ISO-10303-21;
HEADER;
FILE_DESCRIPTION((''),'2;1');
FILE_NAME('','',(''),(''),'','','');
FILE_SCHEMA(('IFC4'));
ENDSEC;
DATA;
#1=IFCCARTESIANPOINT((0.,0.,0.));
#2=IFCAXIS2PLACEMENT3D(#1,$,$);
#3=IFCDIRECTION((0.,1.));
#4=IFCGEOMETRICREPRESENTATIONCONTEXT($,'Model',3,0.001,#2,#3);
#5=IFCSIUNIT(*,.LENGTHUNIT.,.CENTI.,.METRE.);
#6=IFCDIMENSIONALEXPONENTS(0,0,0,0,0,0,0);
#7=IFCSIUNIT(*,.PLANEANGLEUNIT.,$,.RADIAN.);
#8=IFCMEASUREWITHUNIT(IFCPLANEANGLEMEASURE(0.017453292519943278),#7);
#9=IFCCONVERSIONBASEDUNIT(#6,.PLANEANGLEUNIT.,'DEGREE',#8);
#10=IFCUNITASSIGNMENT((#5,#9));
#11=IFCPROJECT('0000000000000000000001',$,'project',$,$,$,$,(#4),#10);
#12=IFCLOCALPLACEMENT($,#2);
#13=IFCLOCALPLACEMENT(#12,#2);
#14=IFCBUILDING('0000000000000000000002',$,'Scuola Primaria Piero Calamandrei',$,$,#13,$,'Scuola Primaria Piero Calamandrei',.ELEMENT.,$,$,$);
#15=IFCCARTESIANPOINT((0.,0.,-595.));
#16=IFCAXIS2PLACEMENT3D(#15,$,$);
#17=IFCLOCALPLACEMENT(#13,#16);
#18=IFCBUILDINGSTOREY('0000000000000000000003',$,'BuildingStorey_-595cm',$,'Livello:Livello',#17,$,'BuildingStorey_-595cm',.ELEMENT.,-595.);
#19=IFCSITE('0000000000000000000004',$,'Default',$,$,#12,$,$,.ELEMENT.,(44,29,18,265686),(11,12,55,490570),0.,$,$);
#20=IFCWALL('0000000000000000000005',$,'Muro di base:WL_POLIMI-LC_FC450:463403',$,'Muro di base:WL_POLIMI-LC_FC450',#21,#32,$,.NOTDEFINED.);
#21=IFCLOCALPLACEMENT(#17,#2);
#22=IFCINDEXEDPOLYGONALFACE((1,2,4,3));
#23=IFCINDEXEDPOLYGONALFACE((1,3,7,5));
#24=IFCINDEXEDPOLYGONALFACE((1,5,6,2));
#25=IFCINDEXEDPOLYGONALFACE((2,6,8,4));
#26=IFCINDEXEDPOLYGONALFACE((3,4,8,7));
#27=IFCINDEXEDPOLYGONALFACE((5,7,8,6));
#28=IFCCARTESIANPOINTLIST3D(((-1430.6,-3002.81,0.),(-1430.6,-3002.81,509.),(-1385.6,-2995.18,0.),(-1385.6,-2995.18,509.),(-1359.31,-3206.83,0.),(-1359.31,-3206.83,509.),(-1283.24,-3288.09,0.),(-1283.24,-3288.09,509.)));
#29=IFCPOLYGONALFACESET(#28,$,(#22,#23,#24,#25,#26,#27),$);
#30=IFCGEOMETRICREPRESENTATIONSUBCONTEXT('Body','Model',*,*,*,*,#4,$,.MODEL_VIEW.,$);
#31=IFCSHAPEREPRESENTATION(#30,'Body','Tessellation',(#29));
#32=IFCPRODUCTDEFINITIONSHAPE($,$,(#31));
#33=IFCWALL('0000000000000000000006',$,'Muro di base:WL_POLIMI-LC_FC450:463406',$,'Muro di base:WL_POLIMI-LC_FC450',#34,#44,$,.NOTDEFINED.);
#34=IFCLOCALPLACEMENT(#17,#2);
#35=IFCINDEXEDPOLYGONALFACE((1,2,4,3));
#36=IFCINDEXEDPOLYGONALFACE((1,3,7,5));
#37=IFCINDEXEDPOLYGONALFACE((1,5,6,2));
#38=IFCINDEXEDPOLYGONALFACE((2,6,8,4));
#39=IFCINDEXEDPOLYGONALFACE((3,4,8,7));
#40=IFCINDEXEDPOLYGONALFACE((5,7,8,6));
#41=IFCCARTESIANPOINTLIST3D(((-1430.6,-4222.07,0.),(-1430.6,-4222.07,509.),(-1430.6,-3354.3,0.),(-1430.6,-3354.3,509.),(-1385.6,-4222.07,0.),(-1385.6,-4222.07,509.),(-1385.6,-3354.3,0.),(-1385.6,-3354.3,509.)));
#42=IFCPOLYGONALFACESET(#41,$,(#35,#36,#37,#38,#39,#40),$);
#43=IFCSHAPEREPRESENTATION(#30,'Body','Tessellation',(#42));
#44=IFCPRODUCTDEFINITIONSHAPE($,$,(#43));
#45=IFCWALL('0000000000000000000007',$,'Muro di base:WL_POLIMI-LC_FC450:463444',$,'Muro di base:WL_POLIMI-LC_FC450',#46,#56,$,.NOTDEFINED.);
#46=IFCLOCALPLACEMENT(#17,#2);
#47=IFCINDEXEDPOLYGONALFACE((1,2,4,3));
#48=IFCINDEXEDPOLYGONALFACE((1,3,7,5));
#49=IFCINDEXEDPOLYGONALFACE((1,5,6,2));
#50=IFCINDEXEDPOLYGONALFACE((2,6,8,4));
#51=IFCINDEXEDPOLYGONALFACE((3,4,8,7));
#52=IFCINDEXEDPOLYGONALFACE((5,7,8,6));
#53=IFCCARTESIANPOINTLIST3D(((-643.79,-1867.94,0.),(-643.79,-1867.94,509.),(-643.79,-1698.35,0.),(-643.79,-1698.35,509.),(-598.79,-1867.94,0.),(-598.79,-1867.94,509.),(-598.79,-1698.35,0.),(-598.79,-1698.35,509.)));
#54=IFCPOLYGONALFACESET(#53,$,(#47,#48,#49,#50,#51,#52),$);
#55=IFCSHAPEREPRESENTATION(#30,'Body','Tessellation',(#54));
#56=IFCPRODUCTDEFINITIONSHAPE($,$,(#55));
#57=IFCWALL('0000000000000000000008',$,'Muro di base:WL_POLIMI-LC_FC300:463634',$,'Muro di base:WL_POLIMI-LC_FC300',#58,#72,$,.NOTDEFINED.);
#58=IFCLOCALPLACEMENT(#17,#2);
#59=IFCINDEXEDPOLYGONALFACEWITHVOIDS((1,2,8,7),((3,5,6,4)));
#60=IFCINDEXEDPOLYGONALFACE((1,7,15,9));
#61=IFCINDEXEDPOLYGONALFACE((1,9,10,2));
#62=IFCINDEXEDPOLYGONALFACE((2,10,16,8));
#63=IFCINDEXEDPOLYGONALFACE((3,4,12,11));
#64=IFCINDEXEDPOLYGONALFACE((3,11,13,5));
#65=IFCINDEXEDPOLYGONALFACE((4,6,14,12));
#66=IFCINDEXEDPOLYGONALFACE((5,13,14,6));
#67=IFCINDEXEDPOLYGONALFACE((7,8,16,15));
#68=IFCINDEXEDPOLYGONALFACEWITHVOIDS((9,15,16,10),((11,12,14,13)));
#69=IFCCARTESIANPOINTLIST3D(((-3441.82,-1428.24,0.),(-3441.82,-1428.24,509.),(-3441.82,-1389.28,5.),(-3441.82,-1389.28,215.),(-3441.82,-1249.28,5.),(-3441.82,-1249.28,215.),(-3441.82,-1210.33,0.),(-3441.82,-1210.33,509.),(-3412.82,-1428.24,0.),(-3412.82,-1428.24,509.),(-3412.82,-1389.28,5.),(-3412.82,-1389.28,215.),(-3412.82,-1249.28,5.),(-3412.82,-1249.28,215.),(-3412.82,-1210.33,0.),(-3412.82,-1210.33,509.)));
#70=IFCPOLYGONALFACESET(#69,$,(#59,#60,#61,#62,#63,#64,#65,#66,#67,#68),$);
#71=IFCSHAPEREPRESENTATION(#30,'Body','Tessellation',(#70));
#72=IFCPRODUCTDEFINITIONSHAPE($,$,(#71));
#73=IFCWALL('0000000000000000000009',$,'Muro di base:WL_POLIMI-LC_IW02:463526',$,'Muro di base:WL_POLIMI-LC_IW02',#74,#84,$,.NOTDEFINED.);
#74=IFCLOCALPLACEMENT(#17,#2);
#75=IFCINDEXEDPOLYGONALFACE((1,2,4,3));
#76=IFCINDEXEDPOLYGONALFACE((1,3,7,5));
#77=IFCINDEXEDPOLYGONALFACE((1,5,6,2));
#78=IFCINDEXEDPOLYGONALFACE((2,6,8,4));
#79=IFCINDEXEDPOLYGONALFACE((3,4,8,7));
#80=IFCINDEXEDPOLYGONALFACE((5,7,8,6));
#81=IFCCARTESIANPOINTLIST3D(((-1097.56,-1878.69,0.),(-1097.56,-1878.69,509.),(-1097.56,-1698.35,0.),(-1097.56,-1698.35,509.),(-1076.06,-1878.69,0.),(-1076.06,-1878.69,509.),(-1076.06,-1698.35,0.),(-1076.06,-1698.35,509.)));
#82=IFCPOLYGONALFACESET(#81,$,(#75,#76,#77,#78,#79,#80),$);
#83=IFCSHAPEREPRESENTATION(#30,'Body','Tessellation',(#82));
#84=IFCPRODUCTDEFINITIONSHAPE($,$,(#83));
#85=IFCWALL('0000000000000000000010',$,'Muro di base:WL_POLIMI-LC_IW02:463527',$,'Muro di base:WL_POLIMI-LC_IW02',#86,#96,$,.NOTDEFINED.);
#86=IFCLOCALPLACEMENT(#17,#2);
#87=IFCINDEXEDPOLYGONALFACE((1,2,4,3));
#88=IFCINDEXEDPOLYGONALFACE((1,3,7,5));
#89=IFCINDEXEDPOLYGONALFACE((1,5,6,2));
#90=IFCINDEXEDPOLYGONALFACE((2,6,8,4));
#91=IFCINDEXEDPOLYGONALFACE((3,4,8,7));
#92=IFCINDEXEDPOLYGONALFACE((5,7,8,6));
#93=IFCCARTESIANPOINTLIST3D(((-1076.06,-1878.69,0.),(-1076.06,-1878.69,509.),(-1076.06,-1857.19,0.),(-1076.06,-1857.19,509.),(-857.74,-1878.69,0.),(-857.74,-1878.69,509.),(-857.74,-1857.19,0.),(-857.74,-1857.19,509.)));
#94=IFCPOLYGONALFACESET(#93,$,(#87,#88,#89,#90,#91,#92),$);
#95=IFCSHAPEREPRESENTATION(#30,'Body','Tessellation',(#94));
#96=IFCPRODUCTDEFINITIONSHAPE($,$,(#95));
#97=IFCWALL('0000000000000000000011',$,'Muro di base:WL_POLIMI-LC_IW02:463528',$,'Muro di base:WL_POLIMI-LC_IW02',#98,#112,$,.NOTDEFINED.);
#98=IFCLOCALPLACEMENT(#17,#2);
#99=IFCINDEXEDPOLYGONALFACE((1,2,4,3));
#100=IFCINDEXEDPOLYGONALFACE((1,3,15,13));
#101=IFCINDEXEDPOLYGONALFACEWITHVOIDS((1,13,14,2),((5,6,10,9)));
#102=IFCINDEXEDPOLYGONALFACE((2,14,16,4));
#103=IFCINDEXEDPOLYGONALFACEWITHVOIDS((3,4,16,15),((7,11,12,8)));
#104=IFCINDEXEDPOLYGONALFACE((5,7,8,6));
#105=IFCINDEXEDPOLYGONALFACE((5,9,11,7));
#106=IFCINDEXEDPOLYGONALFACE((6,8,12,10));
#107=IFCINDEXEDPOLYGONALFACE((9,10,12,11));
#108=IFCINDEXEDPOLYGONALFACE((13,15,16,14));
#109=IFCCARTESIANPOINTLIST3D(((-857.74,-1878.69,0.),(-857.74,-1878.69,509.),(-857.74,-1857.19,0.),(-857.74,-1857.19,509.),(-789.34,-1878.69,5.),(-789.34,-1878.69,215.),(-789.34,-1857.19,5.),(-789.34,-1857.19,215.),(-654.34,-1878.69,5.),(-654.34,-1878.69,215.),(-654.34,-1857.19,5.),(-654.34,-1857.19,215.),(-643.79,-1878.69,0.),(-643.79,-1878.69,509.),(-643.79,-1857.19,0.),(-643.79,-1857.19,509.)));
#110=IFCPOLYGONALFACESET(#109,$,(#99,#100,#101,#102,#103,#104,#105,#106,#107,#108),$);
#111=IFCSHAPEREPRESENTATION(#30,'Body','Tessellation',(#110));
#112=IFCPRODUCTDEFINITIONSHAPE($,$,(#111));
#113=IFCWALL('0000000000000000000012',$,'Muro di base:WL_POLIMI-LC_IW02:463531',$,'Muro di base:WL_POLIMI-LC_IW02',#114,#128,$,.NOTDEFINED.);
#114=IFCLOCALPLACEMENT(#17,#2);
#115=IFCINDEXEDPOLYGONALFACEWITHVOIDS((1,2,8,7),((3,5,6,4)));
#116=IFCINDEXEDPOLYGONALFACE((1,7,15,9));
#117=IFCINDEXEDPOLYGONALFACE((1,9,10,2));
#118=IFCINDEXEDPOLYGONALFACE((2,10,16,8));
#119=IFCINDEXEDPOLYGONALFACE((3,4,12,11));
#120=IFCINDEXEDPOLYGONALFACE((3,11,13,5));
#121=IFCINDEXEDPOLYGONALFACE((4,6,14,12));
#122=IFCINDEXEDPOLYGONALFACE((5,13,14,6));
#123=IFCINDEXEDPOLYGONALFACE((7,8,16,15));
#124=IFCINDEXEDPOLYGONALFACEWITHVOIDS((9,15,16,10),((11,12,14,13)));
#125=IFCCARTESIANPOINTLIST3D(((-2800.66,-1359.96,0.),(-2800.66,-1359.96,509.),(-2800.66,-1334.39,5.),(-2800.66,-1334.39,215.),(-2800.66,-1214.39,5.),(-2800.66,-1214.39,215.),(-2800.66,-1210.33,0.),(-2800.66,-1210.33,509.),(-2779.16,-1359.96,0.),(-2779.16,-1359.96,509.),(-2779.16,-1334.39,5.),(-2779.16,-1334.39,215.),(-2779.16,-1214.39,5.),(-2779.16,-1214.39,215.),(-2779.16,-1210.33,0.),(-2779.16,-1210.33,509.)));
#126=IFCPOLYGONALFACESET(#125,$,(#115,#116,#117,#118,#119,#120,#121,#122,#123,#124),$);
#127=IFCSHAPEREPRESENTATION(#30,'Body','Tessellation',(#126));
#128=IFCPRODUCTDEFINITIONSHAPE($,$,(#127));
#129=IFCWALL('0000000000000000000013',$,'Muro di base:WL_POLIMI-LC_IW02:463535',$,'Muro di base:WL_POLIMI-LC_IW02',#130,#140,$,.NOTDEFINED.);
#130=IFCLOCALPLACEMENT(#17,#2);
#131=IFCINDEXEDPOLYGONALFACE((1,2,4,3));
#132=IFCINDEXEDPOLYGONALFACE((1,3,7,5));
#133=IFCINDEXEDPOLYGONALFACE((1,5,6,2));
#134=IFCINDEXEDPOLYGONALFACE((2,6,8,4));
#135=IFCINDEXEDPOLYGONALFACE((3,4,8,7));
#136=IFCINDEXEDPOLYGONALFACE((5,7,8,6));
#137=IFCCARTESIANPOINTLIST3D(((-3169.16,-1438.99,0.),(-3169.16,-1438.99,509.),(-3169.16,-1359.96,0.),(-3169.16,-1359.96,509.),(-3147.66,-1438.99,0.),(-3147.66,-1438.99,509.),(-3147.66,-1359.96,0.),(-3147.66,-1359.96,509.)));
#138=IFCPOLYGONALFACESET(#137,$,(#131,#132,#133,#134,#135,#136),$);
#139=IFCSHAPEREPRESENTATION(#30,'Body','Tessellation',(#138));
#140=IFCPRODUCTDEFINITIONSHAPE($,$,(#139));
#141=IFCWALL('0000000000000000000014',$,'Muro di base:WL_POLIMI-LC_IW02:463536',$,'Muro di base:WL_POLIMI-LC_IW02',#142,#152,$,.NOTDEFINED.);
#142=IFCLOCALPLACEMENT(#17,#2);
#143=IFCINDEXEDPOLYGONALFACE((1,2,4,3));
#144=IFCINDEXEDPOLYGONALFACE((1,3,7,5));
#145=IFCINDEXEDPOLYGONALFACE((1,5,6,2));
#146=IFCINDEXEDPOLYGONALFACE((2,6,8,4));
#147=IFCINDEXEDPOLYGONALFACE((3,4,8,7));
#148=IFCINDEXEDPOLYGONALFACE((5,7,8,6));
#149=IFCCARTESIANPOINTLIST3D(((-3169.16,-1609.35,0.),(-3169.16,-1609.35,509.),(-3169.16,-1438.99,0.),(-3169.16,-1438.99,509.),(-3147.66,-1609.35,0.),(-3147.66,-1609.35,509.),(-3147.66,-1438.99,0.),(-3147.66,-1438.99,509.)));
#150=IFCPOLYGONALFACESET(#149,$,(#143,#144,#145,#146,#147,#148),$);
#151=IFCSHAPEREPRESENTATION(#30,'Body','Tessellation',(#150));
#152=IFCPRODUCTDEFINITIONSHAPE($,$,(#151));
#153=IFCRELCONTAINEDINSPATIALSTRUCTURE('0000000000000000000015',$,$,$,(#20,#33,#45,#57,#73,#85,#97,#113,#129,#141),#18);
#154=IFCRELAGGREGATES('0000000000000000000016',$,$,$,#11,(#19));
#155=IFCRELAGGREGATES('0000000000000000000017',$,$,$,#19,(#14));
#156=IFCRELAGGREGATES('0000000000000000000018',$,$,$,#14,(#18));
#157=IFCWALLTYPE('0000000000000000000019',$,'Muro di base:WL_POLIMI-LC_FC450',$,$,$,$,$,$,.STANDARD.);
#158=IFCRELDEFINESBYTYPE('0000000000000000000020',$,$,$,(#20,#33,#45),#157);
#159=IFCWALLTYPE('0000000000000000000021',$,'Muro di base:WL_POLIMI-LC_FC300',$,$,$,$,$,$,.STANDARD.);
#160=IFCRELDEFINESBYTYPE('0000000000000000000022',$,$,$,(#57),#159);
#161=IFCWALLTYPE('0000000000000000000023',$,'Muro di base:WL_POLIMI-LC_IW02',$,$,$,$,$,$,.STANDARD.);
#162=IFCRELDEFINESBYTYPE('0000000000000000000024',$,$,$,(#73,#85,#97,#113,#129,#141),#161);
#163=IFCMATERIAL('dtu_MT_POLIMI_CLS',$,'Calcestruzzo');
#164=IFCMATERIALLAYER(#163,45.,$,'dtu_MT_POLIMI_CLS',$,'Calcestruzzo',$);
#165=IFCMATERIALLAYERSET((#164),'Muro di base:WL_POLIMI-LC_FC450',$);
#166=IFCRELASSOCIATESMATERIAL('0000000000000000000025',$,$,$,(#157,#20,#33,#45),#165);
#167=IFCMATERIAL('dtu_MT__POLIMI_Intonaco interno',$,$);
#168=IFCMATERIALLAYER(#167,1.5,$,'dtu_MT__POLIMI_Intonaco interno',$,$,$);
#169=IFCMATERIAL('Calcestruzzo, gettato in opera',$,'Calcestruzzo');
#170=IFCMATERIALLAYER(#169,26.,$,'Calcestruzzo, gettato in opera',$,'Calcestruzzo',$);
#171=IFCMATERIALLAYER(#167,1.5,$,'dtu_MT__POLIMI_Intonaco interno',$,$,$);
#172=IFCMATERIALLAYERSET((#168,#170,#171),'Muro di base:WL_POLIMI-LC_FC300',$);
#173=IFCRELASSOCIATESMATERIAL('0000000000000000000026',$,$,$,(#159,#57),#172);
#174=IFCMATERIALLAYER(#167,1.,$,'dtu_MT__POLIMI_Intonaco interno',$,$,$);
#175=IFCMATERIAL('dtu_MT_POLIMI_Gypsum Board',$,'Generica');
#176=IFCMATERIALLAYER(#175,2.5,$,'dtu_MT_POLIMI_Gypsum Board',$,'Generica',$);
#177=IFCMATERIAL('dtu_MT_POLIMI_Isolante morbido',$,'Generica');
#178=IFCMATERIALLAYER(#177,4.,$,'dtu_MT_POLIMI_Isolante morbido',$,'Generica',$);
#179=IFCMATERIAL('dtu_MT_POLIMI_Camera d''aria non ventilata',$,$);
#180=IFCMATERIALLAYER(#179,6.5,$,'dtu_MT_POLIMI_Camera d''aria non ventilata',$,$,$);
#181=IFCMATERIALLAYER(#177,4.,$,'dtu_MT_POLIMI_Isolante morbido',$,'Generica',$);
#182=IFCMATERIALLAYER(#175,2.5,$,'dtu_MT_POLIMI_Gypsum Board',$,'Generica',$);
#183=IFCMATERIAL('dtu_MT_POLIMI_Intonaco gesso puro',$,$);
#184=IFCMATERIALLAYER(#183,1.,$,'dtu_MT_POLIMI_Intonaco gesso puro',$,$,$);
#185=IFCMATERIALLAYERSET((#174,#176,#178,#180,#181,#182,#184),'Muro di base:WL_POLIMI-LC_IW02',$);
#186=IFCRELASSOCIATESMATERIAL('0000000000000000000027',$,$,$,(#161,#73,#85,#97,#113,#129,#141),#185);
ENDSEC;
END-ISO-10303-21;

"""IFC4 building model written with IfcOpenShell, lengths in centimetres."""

from ifc_helpers import new_model, entity, si_unit, converted_unit, direction, frame, frame_2d, origin, place, context, subcontext, project, spatial, polyline, rectangle, outline, extrude, clip, bounded_halfspace, material, layer, layer_set, layer_usage, type_object, element, save


model = new_model("IFC4")

# Units and contexts
model_context = context("Model", 3, precision=0.001, world=origin(), true_north=direction((0.0, 1.0)))
body_context = subcontext(model_context, "Body", "Model", "MODEL_VIEW")
ifc_project = project(units=[si_unit("LENGTHUNIT", "METRE", prefix="CENTI"), converted_unit("PLANEANGLEUNIT", "DEGREE", entity("IfcPlaneAngleMeasure", 0.017453292519943278), si_unit("PLANEANGLEUNIT", "RADIAN"), dimensions=[0, 0, 0, 0, 0, 0, 0])], contexts=[model_context])

# Site, building, storey
site_placement = place(None, origin())
site = spatial("IfcSite", under=ifc_project, at=site_placement, Name="Default", CompositionType="ELEMENT", RefLatitude=(44, 29, 18, 265686), RefLongitude=(11, 12, 55, 490570), RefElevation=0.0)
building_placement = place(site_placement, origin())
building = spatial("IfcBuilding", under=site, at=building_placement, Name="Scuola Primaria Piero Calamandrei", LongName="Scuola Primaria Piero Calamandrei", CompositionType="ELEMENT")
storey_placement = place(building_placement, frame((0.0, 0.0, -595.0)))
storey = spatial("IfcBuildingStorey", under=building, at=storey_placement, Name="BuildingStorey_-595cm", ObjectType="Livello:Livello", LongName="BuildingStorey_-595cm", CompositionType="ELEMENT", Elevation=-595.0)

# Walls
ifc_material_1 = material(Name="dtu_MT_POLIMI_CLS", Category="Calcestruzzo")
ifc_layer_1 = layer(ifc_material_1, 45.0, Name="dtu_MT_POLIMI_CLS", Category="Calcestruzzo")
ifc_layer_set_1 = layer_set([ifc_layer_1], Name="Muro di base:WL_POLIMI-LC_FC450")
wall_type_1 = type_object("IfcWallType", Name="Muro di base:WL_POLIMI-LC_FC450", PredefinedType="STANDARD", material=ifc_layer_set_1)
ifc_layer_usage_1 = layer_usage(ifc_layer_set_1, "AXIS2", "NEGATIVE", 22.5)
wall_1_placement = place(storey_placement, frame((-1409.36, -2995.39, 0.0), z_axis=(0.0, 0.0, 1.0), x_axis=(0.32988, -0.944023, 0.0)))
element("IfcWall", 1, at=wall_1_placement, inside=storey, type_object=wall_type_1, material=ifc_layer_usage_1, Name="Muro di base:WL_POLIMI-LC_FC450:463403", ObjectType="Muro di base:WL_POLIMI-LC_FC450", PredefinedType="NOTDEFINED", context=body_context, shape_type="Clipping", body=[
    clip(extrude(outline(polyline([(216.11, -22.5), (317.92, 22.5), (218.98, 22.5), (7.64, 22.5), (0.0, -22.5), (216.11, -22.5)])), origin(), (0.0, 0.0, 1.0), 509.0), bounded_halfspace(frame((0.0, -22.5, 509.0), z_axis=(0.0, 0.0, 1.0), x_axis=(0.32988, 0.944023, 0.0)), False, frame((0.0, -22.5, 509.0)), polyline([(0.0, 0.0), (216.11, 0.0), (317.92, 45.0), (218.98, 45.0), (7.64, 45.0), (0.0, 0.0)]))),
])
ifc_layer_usage_2 = layer_usage(ifc_layer_set_1, "AXIS2", "NEGATIVE", 22.5)
wall_2_placement = place(storey_placement, frame((-1408.1, -3354.3, 0.0), z_axis=(0.0, 0.0, 1.0), x_axis=(0.0, -1.0, 0.0)))
element("IfcWall", 2, at=wall_2_placement, inside=storey, type_object=wall_type_1, material=ifc_layer_usage_2, Name="Muro di base:WL_POLIMI-LC_FC450:463406", ObjectType="Muro di base:WL_POLIMI-LC_FC450", PredefinedType="NOTDEFINED", context=body_context, shape_type="Clipping", body=[
    clip(extrude(rectangle(XDim=867.78, YDim=45.0, at=frame_2d((433.89, 0.0), x_axis=(-1.0, 0.0))), origin(), (0.0, 0.0, 1.0), 509.0), bounded_halfspace(frame((0.0, -22.5, 509.0), z_axis=(0.0, 0.0, 1.0), x_axis=(0.0, 1.0, 0.0)), False, frame((0.0, -22.5, 509.0)), polyline([(0.0, 0.0), (867.78, 0.0), (867.78, 45.0), (0.0, 45.0), (0.0, 0.0)]))),
])
ifc_layer_usage_3 = layer_usage(ifc_layer_set_1, "AXIS2", "NEGATIVE", 22.5)
wall_3_placement = place(storey_placement, frame((-621.29, -1698.35, 0.0), z_axis=(0.0, 0.0, 1.0), x_axis=(0.0, -1.0, 0.0)))
element("IfcWall", 3, at=wall_3_placement, inside=storey, type_object=wall_type_1, material=ifc_layer_usage_3, Name="Muro di base:WL_POLIMI-LC_FC450:463444", ObjectType="Muro di base:WL_POLIMI-LC_FC450", PredefinedType="NOTDEFINED", context=body_context, shape_type="Clipping", body=[
    clip(extrude(rectangle(XDim=169.58, YDim=45.0, at=frame_2d((84.79, 0.0), x_axis=(-1.0, 0.0))), origin(), (0.0, 0.0, 1.0), 509.0), bounded_halfspace(frame((0.0, -22.5, 509.0), z_axis=(0.0, 0.0, 1.0), x_axis=(0.0, 1.0, 0.0)), False, frame((0.0, -22.5, 509.0)), polyline([(0.0, 0.0), (10.75, 0.0), (158.83, 0.0), (169.58, 0.0), (169.58, 45.0), (0.0, 45.0), (0.0, 0.0)]))),
])

# Wall, opening
ifc_material_2 = material(Name="dtu_MT__POLIMI_Intonaco interno")
ifc_layer_2 = layer(ifc_material_2, 1.5, Name="dtu_MT__POLIMI_Intonaco interno")
ifc_material_3 = material(Name="Calcestruzzo, gettato in opera", Category="Calcestruzzo")
ifc_layer_3 = layer(ifc_material_3, 26.0, Name="Calcestruzzo, gettato in opera", Category="Calcestruzzo")
ifc_layer_4 = layer(ifc_material_2, 1.5, Name="dtu_MT__POLIMI_Intonaco interno")
ifc_layer_set_2 = layer_set([ifc_layer_2, ifc_layer_3, ifc_layer_4], Name="Muro di base:WL_POLIMI-LC_FC300")
ifc_layer_usage_4 = layer_usage(ifc_layer_set_2, "AXIS2", "NEGATIVE", 14.5)
wall_type_2 = type_object("IfcWallType", Name="Muro di base:WL_POLIMI-LC_FC300", PredefinedType="STANDARD", material=ifc_layer_set_2)
wall_4_placement = place(storey_placement, frame((-3427.32, -1428.24, 0.0), z_axis=(0.0, 0.0, 1.0), x_axis=(0.0, 1.0, 0.0)))
wall_4 = element("IfcWall", 4, at=wall_4_placement, inside=storey, type_object=wall_type_2, material=ifc_layer_usage_4, Name="Muro di base:WL_POLIMI-LC_FC300:463634", ObjectType="Muro di base:WL_POLIMI-LC_FC300", PredefinedType="NOTDEFINED", context=body_context, shape_type="SweptSolid", body=[
    extrude(rectangle(XDim=217.91, YDim=29.0, at=frame_2d((108.96, 0.0), x_axis=(-1.0, 0.0))), origin(), (0.0, 0.0, 1.0), 509.0),
])
opening_1_placement = place(wall_4_placement, frame((38.96, -14.5, 5.0)))
element("IfcOpeningElement", 5, at=opening_1_placement, cuts=wall_4, PredefinedType="OPENING", context=body_context, shape_type="SweptSolid", body=[
    extrude(rectangle(XDim=210.0, YDim=140.0, at=frame_2d((105.0, 70.0), x_axis=(1.0, 0.0))), frame((0.0, 0.0, 0.0), z_axis=(0.0, 1.0, 0.0), x_axis=(0.0, 0.0, 1.0)), (0.0, 0.0, 1.0), 29.0),
])

# Walls
ifc_layer_5 = layer(ifc_material_2, 1.0, Name="dtu_MT__POLIMI_Intonaco interno")
ifc_material_4 = material(Name="dtu_MT_POLIMI_Gypsum Board", Category="Generica")
ifc_layer_6 = layer(ifc_material_4, 2.5, Name="dtu_MT_POLIMI_Gypsum Board", Category="Generica")
ifc_material_5 = material(Name="dtu_MT_POLIMI_Isolante morbido", Category="Generica")
ifc_layer_7 = layer(ifc_material_5, 4.0, Name="dtu_MT_POLIMI_Isolante morbido", Category="Generica")
ifc_material_6 = material(Name="dtu_MT_POLIMI_Camera d'aria non ventilata")
ifc_layer_8 = layer(ifc_material_6, 6.5, Name="dtu_MT_POLIMI_Camera d'aria non ventilata")
ifc_layer_9 = layer(ifc_material_5, 4.0, Name="dtu_MT_POLIMI_Isolante morbido", Category="Generica")
ifc_layer_10 = layer(ifc_material_4, 2.5, Name="dtu_MT_POLIMI_Gypsum Board", Category="Generica")
ifc_material_7 = material(Name="dtu_MT_POLIMI_Intonaco gesso puro")
ifc_layer_11 = layer(ifc_material_7, 1.0, Name="dtu_MT_POLIMI_Intonaco gesso puro")
ifc_layer_set_3 = layer_set([ifc_layer_5, ifc_layer_6, ifc_layer_7, ifc_layer_8, ifc_layer_9, ifc_layer_10, ifc_layer_11], Name="Muro di base:WL_POLIMI-LC_IW02")
ifc_layer_usage_5 = layer_usage(ifc_layer_set_3, "AXIS2", "NEGATIVE", 10.75)
wall_type_3 = type_object("IfcWallType", Name="Muro di base:WL_POLIMI-LC_IW02", PredefinedType="STANDARD", material=ifc_layer_set_3)
wall_5_placement = place(storey_placement, frame((-1086.81, -1698.35, 0.0), z_axis=(0.0, 0.0, 1.0), x_axis=(0.0, -1.0, 0.0)))
element("IfcWall", 6, at=wall_5_placement, inside=storey, type_object=wall_type_3, material=ifc_layer_usage_5, Name="Muro di base:WL_POLIMI-LC_IW02:463526", ObjectType="Muro di base:WL_POLIMI-LC_IW02", PredefinedType="NOTDEFINED", context=body_context, shape_type="SweptSolid", body=[
    extrude(rectangle(XDim=180.33, YDim=21.5, at=frame_2d((90.17, 0.0), x_axis=(-1.0, 0.0))), origin(), (0.0, 0.0, 1.0), 509.0),
])
ifc_layer_usage_6 = layer_usage(ifc_layer_set_3, "AXIS2", "NEGATIVE", 10.75)
wall_6_placement = place(storey_placement, frame((-1076.06, -1867.94, 0.0)))
element("IfcWall", 7, at=wall_6_placement, inside=storey, type_object=wall_type_3, material=ifc_layer_usage_6, Name="Muro di base:WL_POLIMI-LC_IW02:463527", ObjectType="Muro di base:WL_POLIMI-LC_IW02", PredefinedType="NOTDEFINED", context=body_context, shape_type="SweptSolid", body=[
    extrude(rectangle(XDim=218.32, YDim=21.5, at=frame_2d((109.16, 0.0), x_axis=(-1.0, 0.0))), origin(), (0.0, 0.0, 1.0), 509.0),
])

# Walls, openings
ifc_layer_usage_7 = layer_usage(ifc_layer_set_3, "AXIS2", "NEGATIVE", 10.75)
wall_7_placement = place(storey_placement, frame((-857.74, -1867.94, 0.0)))
wall_7 = element("IfcWall", 8, at=wall_7_placement, inside=storey, type_object=wall_type_3, material=ifc_layer_usage_7, Name="Muro di base:WL_POLIMI-LC_IW02:463528", ObjectType="Muro di base:WL_POLIMI-LC_IW02", PredefinedType="NOTDEFINED", context=body_context, shape_type="SweptSolid", body=[
    extrude(rectangle(XDim=213.95, YDim=21.5, at=frame_2d((106.98, 0.0), x_axis=(-1.0, 0.0))), origin(), (0.0, 0.0, 1.0), 509.0),
])
opening_2_placement = place(wall_7_placement, frame((203.4, 10.75, 5.0)))
element("IfcOpeningElement", 9, at=opening_2_placement, cuts=wall_7, PredefinedType="OPENING", context=body_context, shape_type="SweptSolid", body=[
    extrude(rectangle(XDim=210.0, YDim=135.0, at=frame_2d((105.0, 67.5), x_axis=(-1.0, 0.0))), frame((0.0, 0.0, 0.0), z_axis=(0.0, -1.0, 0.0), x_axis=(0.0, 0.0, 1.0)), (0.0, 0.0, 1.0), 21.5),
])
ifc_layer_usage_8 = layer_usage(ifc_layer_set_3, "AXIS2", "NEGATIVE", 10.75)
wall_8_placement = place(storey_placement, frame((-2789.91, -1359.96, 0.0), z_axis=(0.0, 0.0, 1.0), x_axis=(0.0, 1.0, 0.0)))
wall_8 = element("IfcWall", 10, at=wall_8_placement, inside=storey, type_object=wall_type_3, material=ifc_layer_usage_8, Name="Muro di base:WL_POLIMI-LC_IW02:463531", ObjectType="Muro di base:WL_POLIMI-LC_IW02", PredefinedType="NOTDEFINED", context=body_context, shape_type="SweptSolid", body=[
    extrude(rectangle(XDim=149.63, YDim=21.5, at=frame_2d((74.82, 0.0), x_axis=(-1.0, 0.0))), origin(), (0.0, 0.0, 1.0), 509.0),
])
opening_3_placement = place(wall_8_placement, frame((25.57, -10.75, 5.0)))
element("IfcOpeningElement", 11, at=opening_3_placement, cuts=wall_8, PredefinedType="OPENING", context=body_context, shape_type="SweptSolid", body=[
    extrude(rectangle(XDim=210.0, YDim=120.0, at=frame_2d((105.0, 60.0), x_axis=(1.0, 0.0))), frame((0.0, 0.0, 0.0), z_axis=(0.0, 1.0, 0.0), x_axis=(0.0, 0.0, 1.0)), (0.0, 0.0, 1.0), 21.5),
])

# Walls
ifc_layer_usage_9 = layer_usage(ifc_layer_set_3, "AXIS2", "NEGATIVE", 10.75)
wall_9_placement = place(storey_placement, frame((-3158.41, -1438.99, 0.0), z_axis=(0.0, 0.0, 1.0), x_axis=(0.0, 1.0, 0.0)))
element("IfcWall", 12, at=wall_9_placement, inside=storey, type_object=wall_type_3, material=ifc_layer_usage_9, Name="Muro di base:WL_POLIMI-LC_IW02:463535", ObjectType="Muro di base:WL_POLIMI-LC_IW02", PredefinedType="NOTDEFINED", context=body_context, shape_type="SweptSolid", body=[
    extrude(rectangle(XDim=79.03, YDim=21.5, at=frame_2d((39.52, 0.0), x_axis=(-1.0, 0.0))), origin(), (0.0, 0.0, 1.0), 509.0),
])
ifc_layer_usage_10 = layer_usage(ifc_layer_set_3, "AXIS2", "NEGATIVE", 10.75)
wall_10_placement = place(storey_placement, frame((-3158.41, -1609.35, 0.0), z_axis=(0.0, 0.0, 1.0), x_axis=(0.0, 1.0, 0.0)))
element("IfcWall", 13, at=wall_10_placement, inside=storey, type_object=wall_type_3, material=ifc_layer_usage_10, Name="Muro di base:WL_POLIMI-LC_IW02:463536", ObjectType="Muro di base:WL_POLIMI-LC_IW02", PredefinedType="NOTDEFINED", context=body_context, shape_type="SweptSolid", body=[
    extrude(rectangle(XDim=170.36, YDim=21.5, at=frame_2d((85.18, 0.0), x_axis=(-1.0, 0.0))), origin(), (0.0, 0.0, 1.0), 509.0),
])

save(model, "model.ifc")
